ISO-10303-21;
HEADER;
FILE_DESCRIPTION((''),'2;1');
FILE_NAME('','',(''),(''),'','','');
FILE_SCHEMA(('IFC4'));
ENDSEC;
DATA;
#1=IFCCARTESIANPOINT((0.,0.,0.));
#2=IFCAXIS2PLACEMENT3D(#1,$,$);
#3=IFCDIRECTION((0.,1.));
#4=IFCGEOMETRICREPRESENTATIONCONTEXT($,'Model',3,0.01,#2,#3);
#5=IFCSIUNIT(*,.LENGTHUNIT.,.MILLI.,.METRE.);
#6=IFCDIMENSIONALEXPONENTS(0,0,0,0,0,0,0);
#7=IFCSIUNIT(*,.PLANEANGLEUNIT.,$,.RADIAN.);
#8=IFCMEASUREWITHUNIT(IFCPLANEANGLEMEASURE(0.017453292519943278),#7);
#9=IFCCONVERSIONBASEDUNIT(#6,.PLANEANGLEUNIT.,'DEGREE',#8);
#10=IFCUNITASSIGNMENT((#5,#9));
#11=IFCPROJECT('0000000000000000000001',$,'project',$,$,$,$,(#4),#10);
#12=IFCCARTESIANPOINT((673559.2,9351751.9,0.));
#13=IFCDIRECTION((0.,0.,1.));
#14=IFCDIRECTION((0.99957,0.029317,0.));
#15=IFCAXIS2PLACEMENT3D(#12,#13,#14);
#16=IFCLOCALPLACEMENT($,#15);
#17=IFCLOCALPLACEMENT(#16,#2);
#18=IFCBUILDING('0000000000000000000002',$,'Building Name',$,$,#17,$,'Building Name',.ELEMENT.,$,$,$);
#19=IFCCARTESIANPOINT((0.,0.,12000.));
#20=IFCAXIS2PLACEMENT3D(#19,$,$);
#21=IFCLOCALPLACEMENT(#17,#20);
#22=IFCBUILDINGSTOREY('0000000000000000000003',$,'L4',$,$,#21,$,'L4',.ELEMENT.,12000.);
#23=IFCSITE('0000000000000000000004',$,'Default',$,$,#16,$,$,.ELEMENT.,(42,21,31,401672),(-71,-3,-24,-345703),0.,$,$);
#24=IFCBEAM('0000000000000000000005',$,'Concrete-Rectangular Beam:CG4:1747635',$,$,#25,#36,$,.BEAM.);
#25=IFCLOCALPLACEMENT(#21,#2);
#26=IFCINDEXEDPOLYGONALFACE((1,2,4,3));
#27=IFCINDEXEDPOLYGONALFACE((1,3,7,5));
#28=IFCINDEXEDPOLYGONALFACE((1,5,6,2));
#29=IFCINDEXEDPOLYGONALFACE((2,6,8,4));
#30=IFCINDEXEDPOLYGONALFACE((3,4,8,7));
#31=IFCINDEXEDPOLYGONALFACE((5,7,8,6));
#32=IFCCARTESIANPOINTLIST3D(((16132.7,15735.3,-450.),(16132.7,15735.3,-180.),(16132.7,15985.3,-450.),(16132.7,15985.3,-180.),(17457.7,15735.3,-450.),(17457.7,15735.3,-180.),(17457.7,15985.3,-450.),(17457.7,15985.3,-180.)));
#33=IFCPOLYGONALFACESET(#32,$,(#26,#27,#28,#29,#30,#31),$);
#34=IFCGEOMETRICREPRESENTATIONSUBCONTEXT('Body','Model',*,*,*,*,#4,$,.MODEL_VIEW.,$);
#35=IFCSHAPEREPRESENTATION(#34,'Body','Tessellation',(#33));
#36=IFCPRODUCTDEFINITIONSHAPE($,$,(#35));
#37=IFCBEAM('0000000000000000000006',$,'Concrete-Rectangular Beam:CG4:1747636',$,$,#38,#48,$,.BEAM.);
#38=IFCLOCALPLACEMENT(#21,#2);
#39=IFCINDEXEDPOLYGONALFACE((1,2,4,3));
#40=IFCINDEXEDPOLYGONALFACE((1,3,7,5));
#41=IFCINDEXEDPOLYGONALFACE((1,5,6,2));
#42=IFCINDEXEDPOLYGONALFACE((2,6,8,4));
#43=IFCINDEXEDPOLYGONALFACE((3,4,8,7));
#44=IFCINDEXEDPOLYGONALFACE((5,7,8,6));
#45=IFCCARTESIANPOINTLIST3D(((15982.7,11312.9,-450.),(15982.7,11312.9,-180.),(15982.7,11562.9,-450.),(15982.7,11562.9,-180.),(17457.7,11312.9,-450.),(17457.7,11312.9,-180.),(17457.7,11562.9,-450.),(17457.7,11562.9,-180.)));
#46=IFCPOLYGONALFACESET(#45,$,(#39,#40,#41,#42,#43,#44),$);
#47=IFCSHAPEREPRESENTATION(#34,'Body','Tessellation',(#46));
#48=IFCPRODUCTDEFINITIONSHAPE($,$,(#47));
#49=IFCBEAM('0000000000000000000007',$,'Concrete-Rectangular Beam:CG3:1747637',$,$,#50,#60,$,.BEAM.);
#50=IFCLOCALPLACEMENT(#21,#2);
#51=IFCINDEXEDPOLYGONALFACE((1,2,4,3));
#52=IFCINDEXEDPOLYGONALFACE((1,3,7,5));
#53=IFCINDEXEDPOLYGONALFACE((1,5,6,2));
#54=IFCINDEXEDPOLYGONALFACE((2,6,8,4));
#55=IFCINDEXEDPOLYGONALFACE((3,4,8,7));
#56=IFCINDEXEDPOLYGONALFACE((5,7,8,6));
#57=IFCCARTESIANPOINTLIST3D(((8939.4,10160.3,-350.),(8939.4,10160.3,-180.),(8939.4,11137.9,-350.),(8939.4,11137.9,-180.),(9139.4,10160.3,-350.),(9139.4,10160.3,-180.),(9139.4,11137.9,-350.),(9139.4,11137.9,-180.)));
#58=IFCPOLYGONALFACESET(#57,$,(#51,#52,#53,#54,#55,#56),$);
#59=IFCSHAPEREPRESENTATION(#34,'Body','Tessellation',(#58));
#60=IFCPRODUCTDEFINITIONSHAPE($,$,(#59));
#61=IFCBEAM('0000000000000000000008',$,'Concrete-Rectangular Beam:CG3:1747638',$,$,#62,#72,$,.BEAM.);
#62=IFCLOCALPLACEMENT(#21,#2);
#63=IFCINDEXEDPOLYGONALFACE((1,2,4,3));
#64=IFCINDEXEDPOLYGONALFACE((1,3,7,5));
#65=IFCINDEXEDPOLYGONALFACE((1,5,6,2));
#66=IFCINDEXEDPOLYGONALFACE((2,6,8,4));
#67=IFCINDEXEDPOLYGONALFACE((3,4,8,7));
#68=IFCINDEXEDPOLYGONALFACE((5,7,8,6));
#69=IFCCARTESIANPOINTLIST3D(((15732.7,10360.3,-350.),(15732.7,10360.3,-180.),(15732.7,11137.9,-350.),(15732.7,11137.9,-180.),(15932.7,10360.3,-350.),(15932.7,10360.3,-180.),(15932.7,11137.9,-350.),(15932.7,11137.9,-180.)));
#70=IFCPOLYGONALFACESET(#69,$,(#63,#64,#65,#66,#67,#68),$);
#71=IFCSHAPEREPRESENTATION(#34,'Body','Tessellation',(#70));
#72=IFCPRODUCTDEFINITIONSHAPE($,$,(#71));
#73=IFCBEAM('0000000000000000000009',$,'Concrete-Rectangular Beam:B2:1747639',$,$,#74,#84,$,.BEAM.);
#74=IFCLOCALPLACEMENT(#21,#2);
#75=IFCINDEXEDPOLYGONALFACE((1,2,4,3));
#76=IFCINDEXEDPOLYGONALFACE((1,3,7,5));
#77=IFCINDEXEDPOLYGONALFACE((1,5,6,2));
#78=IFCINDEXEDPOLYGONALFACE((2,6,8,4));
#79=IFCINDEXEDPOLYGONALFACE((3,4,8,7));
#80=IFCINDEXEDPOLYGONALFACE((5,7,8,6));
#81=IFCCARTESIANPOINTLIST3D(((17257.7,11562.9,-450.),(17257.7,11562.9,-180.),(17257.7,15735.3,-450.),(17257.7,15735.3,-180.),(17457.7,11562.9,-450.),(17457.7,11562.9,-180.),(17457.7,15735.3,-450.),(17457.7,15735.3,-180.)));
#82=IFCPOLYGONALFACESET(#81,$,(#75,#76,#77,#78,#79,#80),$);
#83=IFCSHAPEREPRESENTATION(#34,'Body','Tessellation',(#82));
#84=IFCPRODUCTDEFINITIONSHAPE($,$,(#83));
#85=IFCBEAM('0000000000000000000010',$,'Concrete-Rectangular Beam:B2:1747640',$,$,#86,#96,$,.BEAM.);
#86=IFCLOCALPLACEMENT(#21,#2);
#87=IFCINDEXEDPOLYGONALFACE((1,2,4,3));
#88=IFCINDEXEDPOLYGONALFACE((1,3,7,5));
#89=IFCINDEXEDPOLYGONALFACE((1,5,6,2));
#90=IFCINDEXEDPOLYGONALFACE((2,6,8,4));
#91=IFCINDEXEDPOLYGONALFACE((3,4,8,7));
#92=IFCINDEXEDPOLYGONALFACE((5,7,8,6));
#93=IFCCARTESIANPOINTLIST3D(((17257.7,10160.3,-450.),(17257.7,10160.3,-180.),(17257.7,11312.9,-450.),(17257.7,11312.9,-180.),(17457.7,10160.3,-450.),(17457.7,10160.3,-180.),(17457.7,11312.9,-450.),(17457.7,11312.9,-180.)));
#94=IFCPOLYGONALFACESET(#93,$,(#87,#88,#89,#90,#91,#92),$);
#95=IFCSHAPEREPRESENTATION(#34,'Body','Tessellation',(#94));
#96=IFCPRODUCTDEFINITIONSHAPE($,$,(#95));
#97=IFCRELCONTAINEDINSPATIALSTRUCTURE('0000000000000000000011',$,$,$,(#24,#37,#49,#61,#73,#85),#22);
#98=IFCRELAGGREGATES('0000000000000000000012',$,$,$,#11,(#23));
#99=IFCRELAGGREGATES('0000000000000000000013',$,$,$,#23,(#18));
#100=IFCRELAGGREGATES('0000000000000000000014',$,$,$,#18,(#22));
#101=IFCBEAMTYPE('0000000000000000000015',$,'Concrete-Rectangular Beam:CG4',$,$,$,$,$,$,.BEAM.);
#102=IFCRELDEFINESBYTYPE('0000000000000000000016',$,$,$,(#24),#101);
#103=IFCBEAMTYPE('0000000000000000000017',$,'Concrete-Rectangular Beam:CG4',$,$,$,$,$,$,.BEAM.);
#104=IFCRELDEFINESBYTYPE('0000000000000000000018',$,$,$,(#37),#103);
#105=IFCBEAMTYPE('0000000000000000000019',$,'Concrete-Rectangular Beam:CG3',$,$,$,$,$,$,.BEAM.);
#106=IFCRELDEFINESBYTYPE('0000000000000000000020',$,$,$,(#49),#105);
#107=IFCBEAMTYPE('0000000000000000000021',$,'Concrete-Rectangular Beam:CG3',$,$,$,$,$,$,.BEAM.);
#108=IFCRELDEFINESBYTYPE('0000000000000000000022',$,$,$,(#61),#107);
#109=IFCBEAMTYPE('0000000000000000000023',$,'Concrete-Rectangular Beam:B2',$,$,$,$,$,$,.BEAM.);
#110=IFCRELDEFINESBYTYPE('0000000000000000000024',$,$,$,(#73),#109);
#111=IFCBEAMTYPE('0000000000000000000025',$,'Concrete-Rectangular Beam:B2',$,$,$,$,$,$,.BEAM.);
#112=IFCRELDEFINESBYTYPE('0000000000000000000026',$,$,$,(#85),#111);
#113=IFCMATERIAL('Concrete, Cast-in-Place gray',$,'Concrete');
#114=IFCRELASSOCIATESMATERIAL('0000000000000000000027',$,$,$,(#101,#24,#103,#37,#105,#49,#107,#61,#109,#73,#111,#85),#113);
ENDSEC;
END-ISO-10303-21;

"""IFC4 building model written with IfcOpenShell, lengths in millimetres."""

from ifc_helpers import new_model, entity, si_unit, converted_unit, direction, frame, origin, place, context, subcontext, project, spatial, indexed_curve, outline, extrude, source, transform, mapped, material, type_object, type_shapes, element, save


model = new_model("IFC4")

# Units and contexts
model_context = context("Model", 3, precision=0.01, world=origin(), true_north=direction((0.0, 1.0)))
body_context = subcontext(model_context, "Body", "Model", "MODEL_VIEW")
ifc_project = project(units=[si_unit("LENGTHUNIT", "METRE", prefix="MILLI"), converted_unit("PLANEANGLEUNIT", "DEGREE", entity("IfcPlaneAngleMeasure", 0.017453292519943278), si_unit("PLANEANGLEUNIT", "RADIAN"), dimensions=[0, 0, 0, 0, 0, 0, 0])], contexts=[model_context])

# Site, building, storey
site_placement = place(None, frame((673559.2, 9351751.9, 0.0), z_axis=(0.0, 0.0, 1.0), x_axis=(0.99957, 0.029317, 0.0)))
site = spatial("IfcSite", under=ifc_project, at=site_placement, Name="Default", CompositionType="ELEMENT", RefLatitude=(42, 21, 31, 401672), RefLongitude=(-71, -3, -24, -345703), RefElevation=0.0)
building_placement = place(site_placement, origin())
building = spatial("IfcBuilding", under=site, at=building_placement, Name="Building Name", LongName="Building Name", CompositionType="ELEMENT")
storey_placement = place(building_placement, frame((0.0, 0.0, 12000.0)))
storey = spatial("IfcBuildingStorey", under=building, at=storey_placement, Name="L4", LongName="L4", CompositionType="ELEMENT", Elevation=12000.0)

# Shared definitions
ifc_material = material(Name="Concrete, Cast-in-Place gray", Category="Concrete")

# Beams
beam_type_1 = type_object("IfcBeamType", Name="Concrete-Rectangular Beam:CG4", PredefinedType="BEAM", material=ifc_material)
shared_shape_1 = source(origin(), body_context, "Body", "SweptSolid", [
    extrude(outline(indexed_curve([(-135.0, -125.0), (135.0, -125.0), (135.0, 125.0), (-135.0, 125.0), (-135.0, -125.0)], self_intersect=False)), frame((17457.7, 15860.3, 11685.0), z_axis=(-1.0, 0.0, 0.0), x_axis=(0.0, 0.0, -1.0)), (0.0, 0.0, 1.0), 1325.0),
])
type_shapes(beam_type_1, [shared_shape_1])
beam_1_placement = place(storey_placement, frame((0.0, 0.0, -12000.0)))
element("IfcBeam", 1, at=beam_1_placement, inside=storey, type_object=beam_type_1, material=ifc_material, Name="Concrete-Rectangular Beam:CG4:1747635", PredefinedType="BEAM", context=body_context, shape_type="MappedRepresentation", body=[
    mapped(shared_shape_1, transform((0.0, 0.0, 0.0), scale=1.0)),
])
beam_type_2 = type_object("IfcBeamType", Name="Concrete-Rectangular Beam:CG4", PredefinedType="BEAM", material=ifc_material)
shared_shape_2 = source(origin(), body_context, "Body", "SweptSolid", [
    extrude(outline(indexed_curve([(-135.0, -125.0), (135.0, -125.0), (135.0, 125.0), (-135.0, 125.0), (-135.0, -125.0)], self_intersect=False)), frame((15982.7, 11437.9, 11685.0), z_axis=(1.0, 0.0, 0.0), x_axis=(0.0, 0.0, -1.0)), (0.0, 0.0, 1.0), 1475.0),
])
type_shapes(beam_type_2, [shared_shape_2])
beam_2_placement = place(storey_placement, frame((0.0, 0.0, -12000.0)))
element("IfcBeam", 2, at=beam_2_placement, inside=storey, type_object=beam_type_2, material=ifc_material, Name="Concrete-Rectangular Beam:CG4:1747636", PredefinedType="BEAM", context=body_context, shape_type="MappedRepresentation", body=[
    mapped(shared_shape_2, transform((0.0, 0.0, 0.0), scale=1.0)),
])
beam_type_3 = type_object("IfcBeamType", Name="Concrete-Rectangular Beam:CG3", PredefinedType="BEAM", material=ifc_material)
shared_shape_3 = source(origin(), body_context, "Body", "SweptSolid", [
    extrude(outline(indexed_curve([(-100.0, -85.0), (100.0, -85.0), (100.0, 85.0), (-100.0, 85.0), (-100.0, -85.0)], self_intersect=False)), frame((9039.4, 11137.9, 11735.0), z_axis=(0.0, -1.0, 0.0), x_axis=(-1.0, 0.0, 0.0)), (0.0, 0.0, 1.0), 977.6),
])
type_shapes(beam_type_3, [shared_shape_3])
beam_3_placement = place(storey_placement, frame((0.0, 0.0, -12000.0)))
element("IfcBeam", 3, at=beam_3_placement, inside=storey, type_object=beam_type_3, material=ifc_material, Name="Concrete-Rectangular Beam:CG3:1747637", PredefinedType="BEAM", context=body_context, shape_type="MappedRepresentation", body=[
    mapped(shared_shape_3, transform((0.0, 0.0, 0.0), scale=1.0)),
])
beam_type_4 = type_object("IfcBeamType", Name="Concrete-Rectangular Beam:CG3", PredefinedType="BEAM", material=ifc_material)
shared_shape_4 = source(origin(), body_context, "Body", "SweptSolid", [
    extrude(outline(indexed_curve([(-100.0, -85.0), (100.0, -85.0), (100.0, 85.0), (-100.0, 85.0), (-100.0, -85.0)], self_intersect=False)), frame((15832.7, 11137.9, 11735.0), z_axis=(0.0, -1.0, 0.0), x_axis=(-1.0, 0.0, 0.0)), (0.0, 0.0, 1.0), 777.6),
])
type_shapes(beam_type_4, [shared_shape_4])
beam_4_placement = place(storey_placement, frame((0.0, 0.0, -12000.0)))
element("IfcBeam", 4, at=beam_4_placement, inside=storey, type_object=beam_type_4, material=ifc_material, Name="Concrete-Rectangular Beam:CG3:1747638", PredefinedType="BEAM", context=body_context, shape_type="MappedRepresentation", body=[
    mapped(shared_shape_4, transform((0.0, 0.0, 0.0), scale=1.0)),
])
beam_type_5 = type_object("IfcBeamType", Name="Concrete-Rectangular Beam:B2", PredefinedType="BEAM", material=ifc_material)
shared_shape_5 = source(origin(), body_context, "Body", "SweptSolid", [
    extrude(outline(indexed_curve([(-100.0, -135.0), (100.0, -135.0), (100.0, 135.0), (-100.0, 135.0), (-100.0, -135.0)], self_intersect=False)), frame((17357.7, 15735.3, 11685.0), z_axis=(0.0, -1.0, 0.0), x_axis=(-1.0, 0.0, 0.0)), (0.0, 0.0, 1.0), 4172.4),
])
type_shapes(beam_type_5, [shared_shape_5])
beam_5_placement = place(storey_placement, frame((0.0, 0.0, -12000.0)))
element("IfcBeam", 5, at=beam_5_placement, inside=storey, type_object=beam_type_5, material=ifc_material, Name="Concrete-Rectangular Beam:B2:1747639", PredefinedType="BEAM", context=body_context, shape_type="MappedRepresentation", body=[
    mapped(shared_shape_5, transform((0.0, 0.0, 0.0), scale=1.0)),
])
beam_type_6 = type_object("IfcBeamType", Name="Concrete-Rectangular Beam:B2", PredefinedType="BEAM", material=ifc_material)
shared_shape_6 = source(origin(), body_context, "Body", "SweptSolid", [
    extrude(outline(indexed_curve([(-100.0, -135.0), (100.0, -135.0), (100.0, 135.0), (-100.0, 135.0), (-100.0, -135.0)], self_intersect=False)), frame((17357.7, 11312.9, 11685.0), z_axis=(0.0, -1.0, 0.0), x_axis=(-1.0, 0.0, 0.0)), (0.0, 0.0, 1.0), 1152.6),
])
type_shapes(beam_type_6, [shared_shape_6])
beam_6_placement = place(storey_placement, frame((0.0, 0.0, -12000.0)))
element("IfcBeam", 6, at=beam_6_placement, inside=storey, type_object=beam_type_6, material=ifc_material, Name="Concrete-Rectangular Beam:B2:1747640", PredefinedType="BEAM", context=body_context, shape_type="MappedRepresentation", body=[
    mapped(shared_shape_6, transform((0.0, 0.0, 0.0), scale=1.0)),
])

save(model, "model.ifc")
